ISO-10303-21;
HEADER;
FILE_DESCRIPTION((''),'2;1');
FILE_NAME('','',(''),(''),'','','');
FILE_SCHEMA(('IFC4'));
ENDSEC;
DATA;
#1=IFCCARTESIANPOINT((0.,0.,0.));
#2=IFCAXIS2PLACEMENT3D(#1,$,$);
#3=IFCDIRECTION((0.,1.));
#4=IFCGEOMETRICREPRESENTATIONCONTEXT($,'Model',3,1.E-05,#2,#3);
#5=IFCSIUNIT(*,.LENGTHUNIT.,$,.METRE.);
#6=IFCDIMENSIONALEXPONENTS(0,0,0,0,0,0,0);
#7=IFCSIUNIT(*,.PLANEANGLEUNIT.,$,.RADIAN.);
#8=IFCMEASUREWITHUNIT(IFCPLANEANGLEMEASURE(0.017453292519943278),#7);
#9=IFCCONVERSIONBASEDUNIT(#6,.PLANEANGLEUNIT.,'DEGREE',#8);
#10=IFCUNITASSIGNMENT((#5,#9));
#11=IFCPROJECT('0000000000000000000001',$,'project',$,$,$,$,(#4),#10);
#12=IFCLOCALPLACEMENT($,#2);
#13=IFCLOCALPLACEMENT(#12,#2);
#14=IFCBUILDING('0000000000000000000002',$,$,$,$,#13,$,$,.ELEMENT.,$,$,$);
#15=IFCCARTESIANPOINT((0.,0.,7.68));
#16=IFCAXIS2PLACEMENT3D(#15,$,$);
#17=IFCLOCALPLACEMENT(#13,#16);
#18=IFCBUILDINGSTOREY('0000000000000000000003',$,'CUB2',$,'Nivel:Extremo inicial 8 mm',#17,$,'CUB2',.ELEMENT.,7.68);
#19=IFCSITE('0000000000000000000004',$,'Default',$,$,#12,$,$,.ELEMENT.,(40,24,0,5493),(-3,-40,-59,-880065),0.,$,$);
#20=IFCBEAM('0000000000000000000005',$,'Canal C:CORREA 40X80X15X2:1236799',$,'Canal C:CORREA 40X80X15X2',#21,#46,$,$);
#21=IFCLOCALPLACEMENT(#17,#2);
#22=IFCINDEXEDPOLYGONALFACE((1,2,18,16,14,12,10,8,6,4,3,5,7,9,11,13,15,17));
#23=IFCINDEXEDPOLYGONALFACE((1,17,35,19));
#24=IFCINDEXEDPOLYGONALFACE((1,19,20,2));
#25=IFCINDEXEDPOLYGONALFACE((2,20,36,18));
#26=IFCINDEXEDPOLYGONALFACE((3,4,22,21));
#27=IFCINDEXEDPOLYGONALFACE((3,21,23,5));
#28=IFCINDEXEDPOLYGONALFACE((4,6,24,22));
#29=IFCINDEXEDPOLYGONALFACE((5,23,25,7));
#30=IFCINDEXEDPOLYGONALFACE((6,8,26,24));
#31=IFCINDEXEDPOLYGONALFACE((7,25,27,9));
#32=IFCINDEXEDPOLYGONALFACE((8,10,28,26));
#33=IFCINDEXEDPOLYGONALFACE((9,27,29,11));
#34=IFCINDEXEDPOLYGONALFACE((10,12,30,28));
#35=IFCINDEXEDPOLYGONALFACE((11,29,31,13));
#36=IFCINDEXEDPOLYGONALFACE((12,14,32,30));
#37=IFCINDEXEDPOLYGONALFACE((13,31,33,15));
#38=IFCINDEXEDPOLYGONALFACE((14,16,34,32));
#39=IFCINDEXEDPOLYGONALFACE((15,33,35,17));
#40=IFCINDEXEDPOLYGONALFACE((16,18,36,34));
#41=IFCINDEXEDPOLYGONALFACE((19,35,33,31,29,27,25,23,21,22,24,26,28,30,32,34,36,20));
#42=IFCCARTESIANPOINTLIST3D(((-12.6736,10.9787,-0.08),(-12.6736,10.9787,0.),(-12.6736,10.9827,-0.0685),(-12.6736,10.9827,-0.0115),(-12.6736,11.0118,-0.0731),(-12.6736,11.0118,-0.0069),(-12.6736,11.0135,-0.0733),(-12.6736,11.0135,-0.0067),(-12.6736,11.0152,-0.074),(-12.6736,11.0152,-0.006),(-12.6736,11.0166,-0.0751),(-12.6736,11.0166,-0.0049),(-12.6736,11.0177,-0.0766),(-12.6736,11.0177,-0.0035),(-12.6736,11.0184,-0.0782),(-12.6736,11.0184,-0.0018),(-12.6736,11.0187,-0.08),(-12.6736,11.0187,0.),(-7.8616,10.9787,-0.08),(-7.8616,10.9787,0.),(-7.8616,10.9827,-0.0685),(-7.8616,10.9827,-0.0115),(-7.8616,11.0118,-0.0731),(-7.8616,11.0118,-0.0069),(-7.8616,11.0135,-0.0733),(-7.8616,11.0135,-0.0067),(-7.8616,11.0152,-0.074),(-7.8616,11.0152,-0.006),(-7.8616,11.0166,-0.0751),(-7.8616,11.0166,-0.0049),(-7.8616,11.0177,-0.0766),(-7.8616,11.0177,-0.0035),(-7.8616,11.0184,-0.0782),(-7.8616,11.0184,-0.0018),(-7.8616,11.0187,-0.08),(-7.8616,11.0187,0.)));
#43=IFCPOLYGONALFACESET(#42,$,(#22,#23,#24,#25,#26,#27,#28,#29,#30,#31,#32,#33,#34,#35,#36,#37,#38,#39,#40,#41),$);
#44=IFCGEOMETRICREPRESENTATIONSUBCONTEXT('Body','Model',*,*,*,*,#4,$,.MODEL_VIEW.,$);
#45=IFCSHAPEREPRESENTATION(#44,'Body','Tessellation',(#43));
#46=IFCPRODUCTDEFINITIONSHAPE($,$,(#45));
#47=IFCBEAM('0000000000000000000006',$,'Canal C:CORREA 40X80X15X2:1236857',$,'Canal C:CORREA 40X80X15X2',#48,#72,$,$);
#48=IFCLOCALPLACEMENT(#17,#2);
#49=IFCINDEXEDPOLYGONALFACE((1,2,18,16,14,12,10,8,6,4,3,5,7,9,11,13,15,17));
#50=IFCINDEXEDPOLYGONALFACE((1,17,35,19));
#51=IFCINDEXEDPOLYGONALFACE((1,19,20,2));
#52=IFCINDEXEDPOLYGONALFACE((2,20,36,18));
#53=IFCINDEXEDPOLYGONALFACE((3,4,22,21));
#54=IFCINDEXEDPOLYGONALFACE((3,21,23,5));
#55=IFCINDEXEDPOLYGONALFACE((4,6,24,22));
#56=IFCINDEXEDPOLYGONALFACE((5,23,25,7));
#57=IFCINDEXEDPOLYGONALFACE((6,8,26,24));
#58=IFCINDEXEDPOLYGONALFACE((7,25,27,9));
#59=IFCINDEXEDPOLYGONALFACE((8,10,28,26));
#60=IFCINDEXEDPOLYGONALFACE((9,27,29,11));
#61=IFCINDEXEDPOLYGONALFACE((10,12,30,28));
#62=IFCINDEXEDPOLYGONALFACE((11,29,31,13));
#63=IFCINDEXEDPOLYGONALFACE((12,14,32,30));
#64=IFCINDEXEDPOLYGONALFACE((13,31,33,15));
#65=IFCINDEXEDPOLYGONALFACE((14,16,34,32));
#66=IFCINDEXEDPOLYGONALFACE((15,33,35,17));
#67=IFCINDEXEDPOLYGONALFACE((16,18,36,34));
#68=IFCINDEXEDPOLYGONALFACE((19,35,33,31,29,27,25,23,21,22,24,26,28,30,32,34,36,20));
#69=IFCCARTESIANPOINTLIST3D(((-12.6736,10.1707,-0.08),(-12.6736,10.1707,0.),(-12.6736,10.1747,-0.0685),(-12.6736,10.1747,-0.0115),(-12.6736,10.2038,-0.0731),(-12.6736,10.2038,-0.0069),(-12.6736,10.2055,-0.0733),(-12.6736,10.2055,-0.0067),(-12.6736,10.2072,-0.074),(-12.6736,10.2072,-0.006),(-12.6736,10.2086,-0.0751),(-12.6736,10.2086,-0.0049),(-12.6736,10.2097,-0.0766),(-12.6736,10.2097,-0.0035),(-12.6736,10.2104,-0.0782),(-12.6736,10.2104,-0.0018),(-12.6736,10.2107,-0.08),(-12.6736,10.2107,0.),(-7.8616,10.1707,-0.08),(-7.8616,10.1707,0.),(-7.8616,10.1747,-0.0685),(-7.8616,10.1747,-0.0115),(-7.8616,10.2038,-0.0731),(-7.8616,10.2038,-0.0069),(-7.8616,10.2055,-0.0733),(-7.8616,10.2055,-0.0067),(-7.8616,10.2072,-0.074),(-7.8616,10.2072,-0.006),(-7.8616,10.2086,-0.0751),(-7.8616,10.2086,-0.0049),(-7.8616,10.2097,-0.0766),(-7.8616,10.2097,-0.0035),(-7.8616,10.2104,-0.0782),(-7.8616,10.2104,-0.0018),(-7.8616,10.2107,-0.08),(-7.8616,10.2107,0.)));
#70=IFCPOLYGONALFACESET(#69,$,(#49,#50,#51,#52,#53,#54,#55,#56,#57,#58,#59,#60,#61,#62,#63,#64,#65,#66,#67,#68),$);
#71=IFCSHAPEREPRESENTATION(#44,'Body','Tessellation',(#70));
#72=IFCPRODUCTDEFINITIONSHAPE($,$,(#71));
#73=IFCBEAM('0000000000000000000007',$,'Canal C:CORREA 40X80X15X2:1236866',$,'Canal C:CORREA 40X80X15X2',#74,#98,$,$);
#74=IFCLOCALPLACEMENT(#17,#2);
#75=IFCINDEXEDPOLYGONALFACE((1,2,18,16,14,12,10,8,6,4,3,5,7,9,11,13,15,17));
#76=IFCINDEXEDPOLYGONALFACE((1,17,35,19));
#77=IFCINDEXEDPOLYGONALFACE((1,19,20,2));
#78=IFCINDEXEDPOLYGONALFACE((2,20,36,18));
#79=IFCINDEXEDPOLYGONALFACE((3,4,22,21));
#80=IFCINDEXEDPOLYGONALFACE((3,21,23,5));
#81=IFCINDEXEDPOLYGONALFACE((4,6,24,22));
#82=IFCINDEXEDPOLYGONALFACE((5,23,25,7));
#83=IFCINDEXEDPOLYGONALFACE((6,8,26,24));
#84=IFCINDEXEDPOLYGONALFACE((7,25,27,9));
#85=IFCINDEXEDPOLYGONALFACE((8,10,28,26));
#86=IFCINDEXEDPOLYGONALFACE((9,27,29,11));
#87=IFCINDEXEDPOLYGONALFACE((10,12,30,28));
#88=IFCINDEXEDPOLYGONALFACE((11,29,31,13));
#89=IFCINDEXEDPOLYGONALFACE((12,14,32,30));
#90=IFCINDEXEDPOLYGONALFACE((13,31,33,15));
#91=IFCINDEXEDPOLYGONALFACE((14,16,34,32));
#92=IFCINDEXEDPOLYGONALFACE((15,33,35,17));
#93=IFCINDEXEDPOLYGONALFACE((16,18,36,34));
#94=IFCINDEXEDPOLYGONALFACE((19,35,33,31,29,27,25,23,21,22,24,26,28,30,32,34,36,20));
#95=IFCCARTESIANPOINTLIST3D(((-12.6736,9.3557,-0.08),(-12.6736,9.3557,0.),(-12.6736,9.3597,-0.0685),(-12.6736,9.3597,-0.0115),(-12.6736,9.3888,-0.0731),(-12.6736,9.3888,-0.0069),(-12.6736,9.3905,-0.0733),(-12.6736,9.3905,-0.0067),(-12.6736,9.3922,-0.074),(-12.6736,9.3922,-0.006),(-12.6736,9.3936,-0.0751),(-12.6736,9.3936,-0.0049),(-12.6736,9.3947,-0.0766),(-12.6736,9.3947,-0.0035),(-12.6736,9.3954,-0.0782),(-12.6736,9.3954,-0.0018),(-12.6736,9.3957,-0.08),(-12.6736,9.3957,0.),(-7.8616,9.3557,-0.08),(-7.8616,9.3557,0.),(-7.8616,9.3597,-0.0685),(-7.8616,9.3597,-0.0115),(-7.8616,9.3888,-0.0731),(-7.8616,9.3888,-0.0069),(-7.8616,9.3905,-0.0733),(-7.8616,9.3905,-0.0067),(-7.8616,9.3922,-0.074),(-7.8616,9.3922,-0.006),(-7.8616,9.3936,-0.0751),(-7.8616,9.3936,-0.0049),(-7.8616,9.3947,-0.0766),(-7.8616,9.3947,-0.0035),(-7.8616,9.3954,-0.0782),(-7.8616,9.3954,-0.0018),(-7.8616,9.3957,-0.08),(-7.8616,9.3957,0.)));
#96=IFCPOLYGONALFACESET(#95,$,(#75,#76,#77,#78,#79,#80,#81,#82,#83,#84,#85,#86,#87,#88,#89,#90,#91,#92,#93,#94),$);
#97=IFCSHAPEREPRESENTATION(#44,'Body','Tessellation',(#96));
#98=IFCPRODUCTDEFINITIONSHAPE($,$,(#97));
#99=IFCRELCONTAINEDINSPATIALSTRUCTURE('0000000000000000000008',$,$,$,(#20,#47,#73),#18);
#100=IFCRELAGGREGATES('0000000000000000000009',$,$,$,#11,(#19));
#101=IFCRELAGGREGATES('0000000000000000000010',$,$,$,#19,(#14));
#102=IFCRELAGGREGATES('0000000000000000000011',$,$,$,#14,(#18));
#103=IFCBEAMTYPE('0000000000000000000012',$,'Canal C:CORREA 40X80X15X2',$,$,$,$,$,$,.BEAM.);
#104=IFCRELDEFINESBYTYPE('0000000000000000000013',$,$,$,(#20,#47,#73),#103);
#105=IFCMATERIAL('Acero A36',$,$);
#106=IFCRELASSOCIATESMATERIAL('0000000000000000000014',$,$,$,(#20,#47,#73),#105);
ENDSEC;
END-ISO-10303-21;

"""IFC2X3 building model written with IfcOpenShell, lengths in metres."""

from ifc_helpers import new_model, entity, si_unit, converted_unit, direction, frame, frame_2d, origin, place, context, subcontext, project, spatial, polyline, circle_curve, parameter, trimmed, segment, composite_curve, outline, extrude, material, type_object, element, save


model = new_model("IFC2X3")

# Units and contexts
model_context = context("Model", 3, precision=1e-05, world=origin(), true_north=direction((0.0, 1.0)))
body_context = subcontext(model_context, "Body", "Model", "MODEL_VIEW")
ifc_project = project(units=[si_unit("LENGTHUNIT", "METRE"), converted_unit("PLANEANGLEUNIT", "DEGREE", entity("IfcPlaneAngleMeasure", 0.017453292519943278), si_unit("PLANEANGLEUNIT", "RADIAN"), dimensions=[0, 0, 0, 0, 0, 0, 0])], contexts=[model_context])

# Site, building, storey
site_placement = place(None, origin())
site = spatial("IfcSite", under=ifc_project, at=site_placement, Name="Default", CompositionType="ELEMENT", RefLatitude=(40, 24, 0, 5493), RefLongitude=(-3, -40, -59, -880065), RefElevation=0.0)
building_placement = place(site_placement, origin())
building = spatial("IfcBuilding", under=site, at=building_placement, CompositionType="ELEMENT")
storey_placement = place(building_placement, frame((0.0, 0.0, 7.68)))
storey = spatial("IfcBuildingStorey", under=building, at=storey_placement, Name="CUB2", ObjectType="Nivel:Extremo inicial 8 mm", LongName="CUB2", CompositionType="ELEMENT", Elevation=7.68)

# Beams
ifc_material = material(Name="Acero A36")
beam_type_1 = type_object("IfcBeamType", Name="Canal C:CORREA 40X80X15X2", PredefinedType="BEAM")
beam_1_placement = place(storey_placement, frame((-7.8236, 10.9899, 0.0), z_axis=(0.0, 0.0, 1.0), x_axis=(-1.0, 0.0, 0.0)))
element("IfcBeam", 1, at=beam_1_placement, inside=storey, type_object=beam_type_1, material=ifc_material, Name="Canal C:CORREA 40X80X15X2:1236799", ObjectType="Canal C:CORREA 40X80X15X2", context=body_context, shape_type="SweptSolid", body=[
    extrude(outline(composite_curve([segment(polyline([(-0.0207, -0.04), (0.0193, -0.04)]), True, "CONTINUOUS"), segment(polyline([(0.0193, -0.04), (0.0193, 0.04)]), True, "CONTINUOUS"), segment(polyline([(0.0193, 0.04), (-0.0207, 0.04)]), True, "CONTINUOUS"), segment(trimmed(circle_curve(frame_2d((-0.0138, 0.04), x_axis=(-1.0, 0.0)), 0.0069), [parameter(0.0)], [parameter(90.0)], True, "PARAMETER"), True, "CONTINUOUS"), segment(polyline([(-0.0138, 0.0331), (0.0153, 0.0285)]), True, "CONTINUOUS"), segment(polyline([(0.0153, 0.0285), (0.0153, -0.0285)]), True, "CONTINUOUS"), segment(polyline([(0.0153, -0.0285), (-0.0138, -0.0331)]), True, "CONTINUOUS"), segment(trimmed(circle_curve(frame_2d((-0.0138, -0.04), x_axis=(0.0, 1.0)), 0.0069), [parameter(0.0)], [parameter(90.0)], True, "PARAMETER"), True, "CONTINUOUS")], self_intersect=False)), frame((0.038, -0.0081, -0.04), z_axis=(1.0, 0.0, 0.0), x_axis=(0.0, 1.0, 0.0)), (0.0, 0.0, 1.0), 4.812),
])
beam_2_placement = place(storey_placement, frame((-7.8236, 10.1819, 0.0), z_axis=(0.0, 0.0, 1.0), x_axis=(-1.0, 0.0, 0.0)))
element("IfcBeam", 2, at=beam_2_placement, inside=storey, type_object=beam_type_1, material=ifc_material, Name="Canal C:CORREA 40X80X15X2:1236857", ObjectType="Canal C:CORREA 40X80X15X2", context=body_context, shape_type="SweptSolid", body=[
    extrude(outline(composite_curve([segment(polyline([(-0.0207, -0.04), (0.0193, -0.04)]), True, "CONTINUOUS"), segment(polyline([(0.0193, -0.04), (0.0193, 0.04)]), True, "CONTINUOUS"), segment(polyline([(0.0193, 0.04), (-0.0207, 0.04)]), True, "CONTINUOUS"), segment(trimmed(circle_curve(frame_2d((-0.0138, 0.04), x_axis=(-1.0, 0.0)), 0.0069), [parameter(0.0)], [parameter(90.0)], True, "PARAMETER"), True, "CONTINUOUS"), segment(polyline([(-0.0138, 0.0331), (0.0153, 0.0285)]), True, "CONTINUOUS"), segment(polyline([(0.0153, 0.0285), (0.0153, -0.0285)]), True, "CONTINUOUS"), segment(polyline([(0.0153, -0.0285), (-0.0138, -0.0331)]), True, "CONTINUOUS"), segment(trimmed(circle_curve(frame_2d((-0.0138, -0.04), x_axis=(0.0, 1.0)), 0.0069), [parameter(0.0)], [parameter(90.0)], True, "PARAMETER"), True, "CONTINUOUS")], self_intersect=False)), frame((0.038, -0.0081, -0.04), z_axis=(1.0, 0.0, 0.0), x_axis=(0.0, 1.0, 0.0)), (0.0, 0.0, 1.0), 4.812),
])
beam_3_placement = place(storey_placement, frame((-7.8236, 9.3669, 0.0), z_axis=(0.0, 0.0, 1.0), x_axis=(-1.0, 0.0, 0.0)))
element("IfcBeam", 3, at=beam_3_placement, inside=storey, type_object=beam_type_1, material=ifc_material, Name="Canal C:CORREA 40X80X15X2:1236866", ObjectType="Canal C:CORREA 40X80X15X2", context=body_context, shape_type="SweptSolid", body=[
    extrude(outline(composite_curve([segment(polyline([(-0.0207, -0.04), (0.0193, -0.04)]), True, "CONTINUOUS"), segment(polyline([(0.0193, -0.04), (0.0193, 0.04)]), True, "CONTINUOUS"), segment(polyline([(0.0193, 0.04), (-0.0207, 0.04)]), True, "CONTINUOUS"), segment(trimmed(circle_curve(frame_2d((-0.0138, 0.04), x_axis=(-1.0, 0.0)), 0.0069), [parameter(0.0)], [parameter(90.0)], True, "PARAMETER"), True, "CONTINUOUS"), segment(polyline([(-0.0138, 0.0331), (0.0153, 0.0285)]), True, "CONTINUOUS"), segment(polyline([(0.0153, 0.0285), (0.0153, -0.0285)]), True, "CONTINUOUS"), segment(polyline([(0.0153, -0.0285), (-0.0138, -0.0331)]), True, "CONTINUOUS"), segment(trimmed(circle_curve(frame_2d((-0.0138, -0.04), x_axis=(0.0, 1.0)), 0.0069), [parameter(0.0)], [parameter(90.0)], True, "PARAMETER"), True, "CONTINUOUS")], self_intersect=False)), frame((0.038, -0.0081, -0.04), z_axis=(1.0, 0.0, 0.0), x_axis=(0.0, 1.0, 0.0)), (0.0, 0.0, 1.0), 4.812),
])

save(model, "model.ifc")
